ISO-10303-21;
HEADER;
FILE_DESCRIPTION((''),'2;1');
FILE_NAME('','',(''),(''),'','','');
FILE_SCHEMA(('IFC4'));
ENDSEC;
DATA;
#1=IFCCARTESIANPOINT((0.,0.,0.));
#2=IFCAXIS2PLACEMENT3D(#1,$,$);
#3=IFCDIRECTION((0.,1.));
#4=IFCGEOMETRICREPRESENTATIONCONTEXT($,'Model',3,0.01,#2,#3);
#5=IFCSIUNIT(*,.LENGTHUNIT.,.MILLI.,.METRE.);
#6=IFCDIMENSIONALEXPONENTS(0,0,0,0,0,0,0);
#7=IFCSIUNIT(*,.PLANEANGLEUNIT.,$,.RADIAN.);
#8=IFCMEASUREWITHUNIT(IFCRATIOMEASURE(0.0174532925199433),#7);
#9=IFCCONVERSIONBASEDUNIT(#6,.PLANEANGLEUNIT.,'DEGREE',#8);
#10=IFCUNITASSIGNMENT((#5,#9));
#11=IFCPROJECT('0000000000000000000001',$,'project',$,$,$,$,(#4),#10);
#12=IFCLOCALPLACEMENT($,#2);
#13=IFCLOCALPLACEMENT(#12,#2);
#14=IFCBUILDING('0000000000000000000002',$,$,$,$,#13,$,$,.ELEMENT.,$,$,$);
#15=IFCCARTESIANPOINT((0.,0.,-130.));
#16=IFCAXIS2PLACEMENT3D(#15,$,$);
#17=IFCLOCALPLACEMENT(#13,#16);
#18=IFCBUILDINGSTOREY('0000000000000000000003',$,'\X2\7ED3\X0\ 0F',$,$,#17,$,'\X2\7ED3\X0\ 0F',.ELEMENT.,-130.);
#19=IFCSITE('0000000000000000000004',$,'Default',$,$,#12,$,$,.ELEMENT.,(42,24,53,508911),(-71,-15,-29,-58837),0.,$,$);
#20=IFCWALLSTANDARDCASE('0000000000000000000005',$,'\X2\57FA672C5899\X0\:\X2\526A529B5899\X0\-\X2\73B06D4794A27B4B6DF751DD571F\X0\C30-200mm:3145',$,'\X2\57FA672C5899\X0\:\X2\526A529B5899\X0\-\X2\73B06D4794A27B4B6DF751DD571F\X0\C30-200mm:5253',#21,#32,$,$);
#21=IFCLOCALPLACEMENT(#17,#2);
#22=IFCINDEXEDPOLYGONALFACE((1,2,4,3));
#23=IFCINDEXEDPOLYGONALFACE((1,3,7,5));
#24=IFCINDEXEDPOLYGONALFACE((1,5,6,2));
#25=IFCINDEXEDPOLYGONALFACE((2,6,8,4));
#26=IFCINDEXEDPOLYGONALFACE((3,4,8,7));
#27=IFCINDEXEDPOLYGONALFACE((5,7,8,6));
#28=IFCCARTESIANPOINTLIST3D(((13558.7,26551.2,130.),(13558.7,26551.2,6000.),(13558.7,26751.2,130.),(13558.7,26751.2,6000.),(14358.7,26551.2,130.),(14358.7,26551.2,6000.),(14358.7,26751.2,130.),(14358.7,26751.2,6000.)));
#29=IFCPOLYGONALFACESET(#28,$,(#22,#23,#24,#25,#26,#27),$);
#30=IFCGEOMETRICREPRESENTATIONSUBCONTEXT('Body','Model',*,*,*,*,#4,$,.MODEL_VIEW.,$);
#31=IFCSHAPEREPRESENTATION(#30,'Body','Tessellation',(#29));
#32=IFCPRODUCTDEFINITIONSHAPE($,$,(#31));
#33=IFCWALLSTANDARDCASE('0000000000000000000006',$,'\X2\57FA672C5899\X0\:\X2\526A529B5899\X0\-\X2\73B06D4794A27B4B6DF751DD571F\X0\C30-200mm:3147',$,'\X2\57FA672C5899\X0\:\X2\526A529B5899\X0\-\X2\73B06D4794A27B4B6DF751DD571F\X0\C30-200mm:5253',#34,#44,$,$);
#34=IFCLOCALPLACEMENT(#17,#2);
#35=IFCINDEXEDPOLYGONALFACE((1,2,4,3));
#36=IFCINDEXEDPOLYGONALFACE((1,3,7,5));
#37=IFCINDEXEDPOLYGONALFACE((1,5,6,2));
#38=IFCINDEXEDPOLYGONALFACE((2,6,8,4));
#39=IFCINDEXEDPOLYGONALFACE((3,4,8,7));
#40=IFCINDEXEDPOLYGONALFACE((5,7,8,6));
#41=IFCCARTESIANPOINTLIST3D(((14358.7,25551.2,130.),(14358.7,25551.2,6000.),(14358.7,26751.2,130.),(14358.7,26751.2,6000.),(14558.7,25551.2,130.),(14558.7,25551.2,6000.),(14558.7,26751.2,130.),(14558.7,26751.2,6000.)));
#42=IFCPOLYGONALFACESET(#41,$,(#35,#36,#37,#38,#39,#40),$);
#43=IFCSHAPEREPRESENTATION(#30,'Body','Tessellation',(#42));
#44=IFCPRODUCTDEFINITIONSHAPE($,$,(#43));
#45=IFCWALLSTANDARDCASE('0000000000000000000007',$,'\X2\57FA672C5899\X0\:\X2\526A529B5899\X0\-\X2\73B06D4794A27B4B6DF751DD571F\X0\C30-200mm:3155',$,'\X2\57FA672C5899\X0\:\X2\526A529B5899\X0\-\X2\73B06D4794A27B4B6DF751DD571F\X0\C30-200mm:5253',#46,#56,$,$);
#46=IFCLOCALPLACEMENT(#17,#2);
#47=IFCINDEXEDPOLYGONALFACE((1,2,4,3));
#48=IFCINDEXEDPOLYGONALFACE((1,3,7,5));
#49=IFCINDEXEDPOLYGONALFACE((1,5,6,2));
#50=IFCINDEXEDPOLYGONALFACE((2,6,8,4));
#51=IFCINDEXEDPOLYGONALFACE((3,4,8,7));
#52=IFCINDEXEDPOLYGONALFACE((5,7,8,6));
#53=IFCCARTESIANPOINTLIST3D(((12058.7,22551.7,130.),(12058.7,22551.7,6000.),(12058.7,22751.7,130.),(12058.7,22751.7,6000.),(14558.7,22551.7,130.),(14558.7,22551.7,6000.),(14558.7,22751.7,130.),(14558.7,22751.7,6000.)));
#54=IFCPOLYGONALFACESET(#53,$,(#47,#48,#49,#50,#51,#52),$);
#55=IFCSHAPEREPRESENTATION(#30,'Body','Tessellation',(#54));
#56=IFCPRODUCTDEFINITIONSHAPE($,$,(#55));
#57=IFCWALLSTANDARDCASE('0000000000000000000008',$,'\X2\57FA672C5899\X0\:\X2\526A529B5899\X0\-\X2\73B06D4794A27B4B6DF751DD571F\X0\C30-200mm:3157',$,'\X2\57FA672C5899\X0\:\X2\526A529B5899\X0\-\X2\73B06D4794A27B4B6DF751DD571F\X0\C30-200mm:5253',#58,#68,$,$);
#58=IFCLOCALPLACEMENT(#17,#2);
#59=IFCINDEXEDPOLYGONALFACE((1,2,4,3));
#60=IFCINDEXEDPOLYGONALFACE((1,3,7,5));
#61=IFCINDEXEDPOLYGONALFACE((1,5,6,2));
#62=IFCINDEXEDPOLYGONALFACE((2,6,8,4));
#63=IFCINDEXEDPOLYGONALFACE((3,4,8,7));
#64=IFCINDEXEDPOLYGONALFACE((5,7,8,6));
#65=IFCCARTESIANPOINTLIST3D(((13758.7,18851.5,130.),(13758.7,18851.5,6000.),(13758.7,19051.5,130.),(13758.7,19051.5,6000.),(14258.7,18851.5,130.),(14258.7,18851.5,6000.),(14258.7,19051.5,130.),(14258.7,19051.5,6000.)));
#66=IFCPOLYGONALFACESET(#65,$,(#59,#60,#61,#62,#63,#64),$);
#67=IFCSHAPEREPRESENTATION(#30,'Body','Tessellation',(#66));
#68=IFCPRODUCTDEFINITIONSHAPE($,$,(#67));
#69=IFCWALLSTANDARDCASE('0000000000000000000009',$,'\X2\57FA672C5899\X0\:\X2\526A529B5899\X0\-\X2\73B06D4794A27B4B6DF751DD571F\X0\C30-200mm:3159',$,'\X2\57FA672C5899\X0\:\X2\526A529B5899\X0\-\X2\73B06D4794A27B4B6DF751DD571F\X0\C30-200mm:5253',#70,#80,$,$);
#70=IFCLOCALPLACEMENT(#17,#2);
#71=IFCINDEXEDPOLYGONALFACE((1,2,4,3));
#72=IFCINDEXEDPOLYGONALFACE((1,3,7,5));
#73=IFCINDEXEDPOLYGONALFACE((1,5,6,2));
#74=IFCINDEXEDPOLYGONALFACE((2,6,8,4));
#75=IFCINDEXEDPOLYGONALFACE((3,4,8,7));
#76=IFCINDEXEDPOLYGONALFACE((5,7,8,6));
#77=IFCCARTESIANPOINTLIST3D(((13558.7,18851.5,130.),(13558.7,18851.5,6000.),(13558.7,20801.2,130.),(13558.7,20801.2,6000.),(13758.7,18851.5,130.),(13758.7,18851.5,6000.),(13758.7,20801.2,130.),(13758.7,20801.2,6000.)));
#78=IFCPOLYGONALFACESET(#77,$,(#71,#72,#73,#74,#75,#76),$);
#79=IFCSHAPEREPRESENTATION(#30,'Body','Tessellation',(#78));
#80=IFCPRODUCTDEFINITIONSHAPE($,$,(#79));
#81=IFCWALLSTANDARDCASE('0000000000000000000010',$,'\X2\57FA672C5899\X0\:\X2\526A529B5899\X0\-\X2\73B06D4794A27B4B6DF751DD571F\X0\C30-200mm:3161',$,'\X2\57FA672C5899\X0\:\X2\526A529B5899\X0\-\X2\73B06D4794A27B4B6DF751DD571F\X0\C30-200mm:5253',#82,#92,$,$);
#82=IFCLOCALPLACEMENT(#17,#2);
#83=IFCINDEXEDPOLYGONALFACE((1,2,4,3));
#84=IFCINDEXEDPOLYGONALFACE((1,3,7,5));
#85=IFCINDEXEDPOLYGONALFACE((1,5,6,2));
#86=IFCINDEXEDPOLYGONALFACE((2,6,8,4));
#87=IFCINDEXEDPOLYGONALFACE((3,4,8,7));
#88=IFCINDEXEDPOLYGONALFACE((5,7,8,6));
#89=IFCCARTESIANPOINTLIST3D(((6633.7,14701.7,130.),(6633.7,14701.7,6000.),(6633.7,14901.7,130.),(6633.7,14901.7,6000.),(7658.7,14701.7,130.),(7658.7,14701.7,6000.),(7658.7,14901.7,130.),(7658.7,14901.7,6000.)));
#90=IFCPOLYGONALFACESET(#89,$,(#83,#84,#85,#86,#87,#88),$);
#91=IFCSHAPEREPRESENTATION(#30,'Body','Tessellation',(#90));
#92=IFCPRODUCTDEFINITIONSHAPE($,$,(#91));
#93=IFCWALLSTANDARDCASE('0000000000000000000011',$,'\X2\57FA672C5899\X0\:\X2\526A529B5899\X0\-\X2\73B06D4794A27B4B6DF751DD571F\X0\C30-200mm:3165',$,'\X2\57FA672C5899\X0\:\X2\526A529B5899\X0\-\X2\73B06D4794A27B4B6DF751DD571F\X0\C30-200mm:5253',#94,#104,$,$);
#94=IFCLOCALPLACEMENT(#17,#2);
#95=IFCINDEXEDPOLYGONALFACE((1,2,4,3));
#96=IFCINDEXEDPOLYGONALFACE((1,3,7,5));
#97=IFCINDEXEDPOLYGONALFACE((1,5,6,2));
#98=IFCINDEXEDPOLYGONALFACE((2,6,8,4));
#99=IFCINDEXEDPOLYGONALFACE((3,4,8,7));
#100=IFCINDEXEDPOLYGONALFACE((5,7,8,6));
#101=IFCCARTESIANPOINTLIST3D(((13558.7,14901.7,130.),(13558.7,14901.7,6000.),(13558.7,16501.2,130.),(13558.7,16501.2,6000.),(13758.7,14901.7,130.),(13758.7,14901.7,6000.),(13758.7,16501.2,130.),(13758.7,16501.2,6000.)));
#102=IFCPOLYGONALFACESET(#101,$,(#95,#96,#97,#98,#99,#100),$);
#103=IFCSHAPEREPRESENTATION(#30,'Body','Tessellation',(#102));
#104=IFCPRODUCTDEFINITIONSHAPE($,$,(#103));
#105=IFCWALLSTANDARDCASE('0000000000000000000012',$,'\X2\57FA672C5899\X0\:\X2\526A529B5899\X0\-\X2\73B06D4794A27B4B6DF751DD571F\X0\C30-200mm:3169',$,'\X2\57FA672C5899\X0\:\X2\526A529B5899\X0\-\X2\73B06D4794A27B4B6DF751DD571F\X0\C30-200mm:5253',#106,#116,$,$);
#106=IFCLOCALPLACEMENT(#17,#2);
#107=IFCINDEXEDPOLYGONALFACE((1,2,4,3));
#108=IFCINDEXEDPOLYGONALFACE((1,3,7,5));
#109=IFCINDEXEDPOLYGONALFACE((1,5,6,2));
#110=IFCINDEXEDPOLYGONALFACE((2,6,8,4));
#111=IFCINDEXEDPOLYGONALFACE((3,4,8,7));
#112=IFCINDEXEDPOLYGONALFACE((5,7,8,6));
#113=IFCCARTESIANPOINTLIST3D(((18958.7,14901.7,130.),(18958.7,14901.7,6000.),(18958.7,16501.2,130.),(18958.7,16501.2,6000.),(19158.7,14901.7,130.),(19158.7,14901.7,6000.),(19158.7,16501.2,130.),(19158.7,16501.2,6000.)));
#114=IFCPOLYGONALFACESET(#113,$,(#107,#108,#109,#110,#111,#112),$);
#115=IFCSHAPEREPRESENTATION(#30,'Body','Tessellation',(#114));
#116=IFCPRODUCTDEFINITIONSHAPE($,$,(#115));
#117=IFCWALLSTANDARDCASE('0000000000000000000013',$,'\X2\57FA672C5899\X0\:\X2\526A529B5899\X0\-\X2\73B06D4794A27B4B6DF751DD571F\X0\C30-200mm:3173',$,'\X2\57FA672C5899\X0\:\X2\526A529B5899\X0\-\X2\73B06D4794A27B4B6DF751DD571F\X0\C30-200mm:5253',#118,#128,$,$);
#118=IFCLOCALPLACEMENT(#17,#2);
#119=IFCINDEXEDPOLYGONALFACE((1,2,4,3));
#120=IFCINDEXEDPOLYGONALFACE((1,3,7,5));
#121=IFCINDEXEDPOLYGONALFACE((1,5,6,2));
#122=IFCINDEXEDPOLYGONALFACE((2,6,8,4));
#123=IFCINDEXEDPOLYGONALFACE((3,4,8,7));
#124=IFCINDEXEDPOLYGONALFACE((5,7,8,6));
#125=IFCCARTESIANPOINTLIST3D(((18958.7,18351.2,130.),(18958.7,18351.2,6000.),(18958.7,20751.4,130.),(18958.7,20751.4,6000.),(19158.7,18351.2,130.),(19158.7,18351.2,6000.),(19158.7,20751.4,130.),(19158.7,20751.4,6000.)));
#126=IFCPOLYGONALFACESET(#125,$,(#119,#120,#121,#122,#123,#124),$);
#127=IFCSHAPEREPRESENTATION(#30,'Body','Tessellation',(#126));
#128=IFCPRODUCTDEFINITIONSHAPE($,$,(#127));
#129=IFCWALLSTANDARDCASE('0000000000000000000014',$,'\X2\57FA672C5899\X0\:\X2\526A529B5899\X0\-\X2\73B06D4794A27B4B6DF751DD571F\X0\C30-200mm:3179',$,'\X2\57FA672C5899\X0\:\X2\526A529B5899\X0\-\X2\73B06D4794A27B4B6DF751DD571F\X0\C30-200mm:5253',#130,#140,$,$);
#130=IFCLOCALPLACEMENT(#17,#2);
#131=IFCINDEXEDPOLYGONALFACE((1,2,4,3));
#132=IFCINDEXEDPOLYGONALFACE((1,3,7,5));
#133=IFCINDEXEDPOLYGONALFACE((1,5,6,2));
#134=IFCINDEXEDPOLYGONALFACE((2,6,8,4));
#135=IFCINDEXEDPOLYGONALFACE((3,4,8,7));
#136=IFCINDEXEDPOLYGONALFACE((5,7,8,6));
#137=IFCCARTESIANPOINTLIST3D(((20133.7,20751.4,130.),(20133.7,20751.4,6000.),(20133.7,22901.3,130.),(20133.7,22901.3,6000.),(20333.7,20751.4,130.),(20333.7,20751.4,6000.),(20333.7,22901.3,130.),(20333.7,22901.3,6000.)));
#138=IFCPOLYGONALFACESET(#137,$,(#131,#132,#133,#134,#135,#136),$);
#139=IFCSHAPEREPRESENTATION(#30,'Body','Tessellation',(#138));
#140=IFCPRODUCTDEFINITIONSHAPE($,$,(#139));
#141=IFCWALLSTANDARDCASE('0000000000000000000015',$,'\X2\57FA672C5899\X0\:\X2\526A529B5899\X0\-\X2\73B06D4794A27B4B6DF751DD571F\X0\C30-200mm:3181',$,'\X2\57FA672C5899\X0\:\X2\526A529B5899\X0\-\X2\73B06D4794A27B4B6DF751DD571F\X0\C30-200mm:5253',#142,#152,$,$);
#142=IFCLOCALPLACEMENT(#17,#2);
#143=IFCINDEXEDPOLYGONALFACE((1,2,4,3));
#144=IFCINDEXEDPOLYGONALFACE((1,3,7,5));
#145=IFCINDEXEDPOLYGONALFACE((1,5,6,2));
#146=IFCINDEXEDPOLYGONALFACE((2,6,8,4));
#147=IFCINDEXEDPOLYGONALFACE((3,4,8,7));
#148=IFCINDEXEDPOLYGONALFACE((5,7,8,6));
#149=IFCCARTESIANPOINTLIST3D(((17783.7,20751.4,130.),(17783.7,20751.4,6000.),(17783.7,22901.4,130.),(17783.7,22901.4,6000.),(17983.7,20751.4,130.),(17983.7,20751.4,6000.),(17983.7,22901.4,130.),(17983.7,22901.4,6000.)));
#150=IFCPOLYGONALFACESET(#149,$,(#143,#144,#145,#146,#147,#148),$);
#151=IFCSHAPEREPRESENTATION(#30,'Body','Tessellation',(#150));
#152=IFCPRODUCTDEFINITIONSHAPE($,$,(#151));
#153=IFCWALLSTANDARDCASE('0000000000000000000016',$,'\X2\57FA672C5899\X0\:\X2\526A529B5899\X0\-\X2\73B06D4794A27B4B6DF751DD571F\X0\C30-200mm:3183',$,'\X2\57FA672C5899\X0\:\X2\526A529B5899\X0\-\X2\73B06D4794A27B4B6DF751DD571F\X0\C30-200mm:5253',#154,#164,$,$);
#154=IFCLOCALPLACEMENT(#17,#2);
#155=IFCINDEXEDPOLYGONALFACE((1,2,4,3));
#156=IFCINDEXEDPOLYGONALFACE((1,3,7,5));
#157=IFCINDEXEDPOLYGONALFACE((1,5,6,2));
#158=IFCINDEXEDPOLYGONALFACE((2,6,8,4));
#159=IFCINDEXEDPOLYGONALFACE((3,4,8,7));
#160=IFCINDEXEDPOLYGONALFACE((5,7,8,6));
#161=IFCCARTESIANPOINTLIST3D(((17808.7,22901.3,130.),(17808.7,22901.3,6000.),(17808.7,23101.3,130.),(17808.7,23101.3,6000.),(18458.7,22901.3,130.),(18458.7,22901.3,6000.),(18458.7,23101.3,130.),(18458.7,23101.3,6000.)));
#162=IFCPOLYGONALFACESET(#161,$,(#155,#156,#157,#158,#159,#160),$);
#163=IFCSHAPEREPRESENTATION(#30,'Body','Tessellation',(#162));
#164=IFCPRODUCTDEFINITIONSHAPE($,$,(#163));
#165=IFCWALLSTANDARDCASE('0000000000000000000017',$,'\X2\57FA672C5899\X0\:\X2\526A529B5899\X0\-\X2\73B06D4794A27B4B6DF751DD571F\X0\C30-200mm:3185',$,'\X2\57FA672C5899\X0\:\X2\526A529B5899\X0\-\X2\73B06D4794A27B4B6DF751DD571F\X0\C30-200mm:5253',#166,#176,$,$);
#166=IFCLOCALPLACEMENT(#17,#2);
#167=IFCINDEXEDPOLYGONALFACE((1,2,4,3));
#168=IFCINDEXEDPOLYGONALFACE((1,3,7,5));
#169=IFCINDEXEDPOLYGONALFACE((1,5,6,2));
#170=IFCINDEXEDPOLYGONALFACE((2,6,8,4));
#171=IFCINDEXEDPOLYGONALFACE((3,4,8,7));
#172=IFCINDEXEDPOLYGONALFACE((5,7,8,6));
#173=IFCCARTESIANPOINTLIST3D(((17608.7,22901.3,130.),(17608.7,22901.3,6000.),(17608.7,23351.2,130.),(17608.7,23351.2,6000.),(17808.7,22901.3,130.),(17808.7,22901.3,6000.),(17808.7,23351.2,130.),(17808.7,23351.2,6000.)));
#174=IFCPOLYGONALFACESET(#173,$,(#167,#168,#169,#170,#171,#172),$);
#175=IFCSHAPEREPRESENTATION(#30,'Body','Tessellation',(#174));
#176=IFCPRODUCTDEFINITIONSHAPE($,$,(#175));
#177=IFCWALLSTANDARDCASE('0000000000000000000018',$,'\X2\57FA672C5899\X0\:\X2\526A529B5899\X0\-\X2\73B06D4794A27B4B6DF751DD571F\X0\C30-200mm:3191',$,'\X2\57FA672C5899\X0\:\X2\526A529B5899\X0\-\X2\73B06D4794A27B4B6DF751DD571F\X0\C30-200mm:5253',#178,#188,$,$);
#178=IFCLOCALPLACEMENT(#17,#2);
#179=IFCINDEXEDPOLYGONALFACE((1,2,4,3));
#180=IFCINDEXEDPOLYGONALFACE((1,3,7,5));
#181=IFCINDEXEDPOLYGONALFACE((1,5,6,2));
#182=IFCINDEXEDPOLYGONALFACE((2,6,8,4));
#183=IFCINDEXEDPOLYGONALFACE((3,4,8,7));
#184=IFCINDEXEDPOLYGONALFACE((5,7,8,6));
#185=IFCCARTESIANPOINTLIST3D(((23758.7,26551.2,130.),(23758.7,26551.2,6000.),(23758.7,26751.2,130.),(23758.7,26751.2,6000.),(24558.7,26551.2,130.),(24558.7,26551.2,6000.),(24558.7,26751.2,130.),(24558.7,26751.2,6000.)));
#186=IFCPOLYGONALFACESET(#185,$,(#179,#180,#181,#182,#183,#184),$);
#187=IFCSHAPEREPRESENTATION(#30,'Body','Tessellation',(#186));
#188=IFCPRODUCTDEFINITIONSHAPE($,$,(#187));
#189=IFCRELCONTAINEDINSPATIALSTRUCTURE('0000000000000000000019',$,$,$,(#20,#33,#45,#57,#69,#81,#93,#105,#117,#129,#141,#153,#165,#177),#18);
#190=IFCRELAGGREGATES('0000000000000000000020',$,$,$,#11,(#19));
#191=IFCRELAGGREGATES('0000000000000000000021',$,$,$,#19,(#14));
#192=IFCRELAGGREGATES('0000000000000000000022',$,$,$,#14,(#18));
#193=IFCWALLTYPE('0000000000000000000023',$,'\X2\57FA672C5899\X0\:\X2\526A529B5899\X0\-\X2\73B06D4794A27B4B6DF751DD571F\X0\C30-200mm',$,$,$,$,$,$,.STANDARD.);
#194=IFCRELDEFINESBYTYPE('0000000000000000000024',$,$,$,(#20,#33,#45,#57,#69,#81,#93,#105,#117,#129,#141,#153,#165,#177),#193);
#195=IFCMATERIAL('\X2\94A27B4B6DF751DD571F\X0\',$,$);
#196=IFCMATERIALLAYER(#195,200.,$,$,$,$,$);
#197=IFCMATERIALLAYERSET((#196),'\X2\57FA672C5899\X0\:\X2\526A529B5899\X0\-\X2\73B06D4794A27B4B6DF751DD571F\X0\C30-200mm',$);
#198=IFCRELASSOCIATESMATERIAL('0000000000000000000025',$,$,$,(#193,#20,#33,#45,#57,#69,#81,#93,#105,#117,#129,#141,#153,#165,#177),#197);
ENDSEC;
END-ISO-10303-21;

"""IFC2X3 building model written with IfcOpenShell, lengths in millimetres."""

from ifc_helpers import new_model, entity, si_unit, converted_unit, direction, frame, frame_2d, origin, place, context, subcontext, project, spatial, rectangle, extrude, material, layer, layer_set, layer_usage, type_object, element, save


model = new_model("IFC2X3")

# Units and contexts
model_context = context("Model", 3, precision=0.01, world=origin(), true_north=direction((0.0, 1.0)))
body_context = subcontext(model_context, "Body", "Model", "MODEL_VIEW")
ifc_project = project(units=[si_unit("LENGTHUNIT", "METRE", prefix="MILLI"), converted_unit("PLANEANGLEUNIT", "DEGREE", entity("IfcRatioMeasure", 0.0174532925199433), si_unit("PLANEANGLEUNIT", "RADIAN"), dimensions=[0, 0, 0, 0, 0, 0, 0])], contexts=[model_context])

# Site, building, storey
site_placement = place(None, origin())
site = spatial("IfcSite", under=ifc_project, at=site_placement, Name="Default", CompositionType="ELEMENT", RefLatitude=(42, 24, 53, 508911), RefLongitude=(-71, -15, -29, -58837), RefElevation=0.0)
building_placement = place(site_placement, origin())
building = spatial("IfcBuilding", under=site, at=building_placement, CompositionType="ELEMENT")
storey_placement = place(building_placement, frame((0.0, 0.0, -130.0)))
storey = spatial("IfcBuildingStorey", under=building, at=storey_placement, Name="结 0F", LongName="结 0F", CompositionType="ELEMENT", Elevation=-130.0)

# Walls
ifc_material = material(Name="钢筋混凝土")
ifc_layer_1 = layer(ifc_material, 200.0)
ifc_layer_set_1 = layer_set([ifc_layer_1], Name="基本墙:剪力墙-现浇钢筋混凝土C30-200mm")
ifc_layer_usage_1 = layer_usage(ifc_layer_set_1, "AXIS2", "NEGATIVE", 100.0)
wall_type_1 = type_object("IfcWallType", Name="基本墙:剪力墙-现浇钢筋混凝土C30-200mm", PredefinedType="STANDARD", material=ifc_layer_set_1)
wall_1_placement = place(storey_placement, frame((13558.7, 26651.2, 130.0)))
element("IfcWallStandardCase", 1, at=wall_1_placement, inside=storey, type_object=wall_type_1, material=ifc_layer_usage_1, Name="基本墙:剪力墙-现浇钢筋混凝土C30-200mm:3145", ObjectType="基本墙:剪力墙-现浇钢筋混凝土C30-200mm:5253", context=body_context, shape_type="SweptSolid", body=[
    extrude(rectangle(XDim=800.0, YDim=200.0, at=frame_2d((400.0, 0.0), x_axis=(-1.0, 0.0))), origin(), (0.0, 0.0, 1.0), 5870.0),
])
ifc_layer_usage_2 = layer_usage(ifc_layer_set_1, "AXIS2", "NEGATIVE", 100.0)
wall_2_placement = place(storey_placement, frame((14458.7, 26751.2, 130.0), z_axis=(0.0, 0.0, 1.0), x_axis=(0.0, -1.0, 0.0)))
element("IfcWallStandardCase", 2, at=wall_2_placement, inside=storey, type_object=wall_type_1, material=ifc_layer_usage_2, Name="基本墙:剪力墙-现浇钢筋混凝土C30-200mm:3147", ObjectType="基本墙:剪力墙-现浇钢筋混凝土C30-200mm:5253", context=body_context, shape_type="SweptSolid", body=[
    extrude(rectangle(XDim=1200.0, YDim=200.0, at=frame_2d((600.0, 0.0), x_axis=(-1.0, 0.0))), origin(), (0.0, 0.0, 1.0), 5870.0),
])
ifc_layer_usage_3 = layer_usage(ifc_layer_set_1, "AXIS2", "NEGATIVE", 100.0)
wall_3_placement = place(storey_placement, frame((12058.7, 22651.7, 130.0)))
element("IfcWallStandardCase", 3, at=wall_3_placement, inside=storey, type_object=wall_type_1, material=ifc_layer_usage_3, Name="基本墙:剪力墙-现浇钢筋混凝土C30-200mm:3155", ObjectType="基本墙:剪力墙-现浇钢筋混凝土C30-200mm:5253", context=body_context, shape_type="SweptSolid", body=[
    extrude(rectangle(XDim=2500.0, YDim=200.0, at=frame_2d((1250.0, 0.0), x_axis=(-1.0, 0.0))), origin(), (0.0, 0.0, 1.0), 5870.0),
])
ifc_layer_usage_4 = layer_usage(ifc_layer_set_1, "AXIS2", "NEGATIVE", 100.0)
wall_4_placement = place(storey_placement, frame((14258.7, 18951.5, 130.0), z_axis=(0.0, 0.0, 1.0), x_axis=(-1.0, 0.0, 0.0)))
element("IfcWallStandardCase", 4, at=wall_4_placement, inside=storey, type_object=wall_type_1, material=ifc_layer_usage_4, Name="基本墙:剪力墙-现浇钢筋混凝土C30-200mm:3157", ObjectType="基本墙:剪力墙-现浇钢筋混凝土C30-200mm:5253", context=body_context, shape_type="SweptSolid", body=[
    extrude(rectangle(XDim=500.0, YDim=200.0, at=frame_2d((250.0, 0.0), x_axis=(-1.0, 0.0))), origin(), (0.0, 0.0, 1.0), 5870.0),
])
ifc_layer_usage_5 = layer_usage(ifc_layer_set_1, "AXIS2", "NEGATIVE", 100.0)
wall_5_placement = place(storey_placement, frame((13658.7, 18851.5, 130.0), z_axis=(0.0, 0.0, 1.0), x_axis=(0.0, 1.0, 0.0)))
element("IfcWallStandardCase", 5, at=wall_5_placement, inside=storey, type_object=wall_type_1, material=ifc_layer_usage_5, Name="基本墙:剪力墙-现浇钢筋混凝土C30-200mm:3159", ObjectType="基本墙:剪力墙-现浇钢筋混凝土C30-200mm:5253", context=body_context, shape_type="SweptSolid", body=[
    extrude(rectangle(XDim=1949.8, YDim=200.0, at=frame_2d((974.9, 0.0), x_axis=(-1.0, 0.0))), origin(), (0.0, 0.0, 1.0), 5870.0),
])
ifc_layer_usage_6 = layer_usage(ifc_layer_set_1, "AXIS2", "NEGATIVE", 100.0)
wall_6_placement = place(storey_placement, frame((7658.7, 14801.7, 130.0), z_axis=(0.0, 0.0, 1.0), x_axis=(-1.0, 0.0, 0.0)))
element("IfcWallStandardCase", 6, at=wall_6_placement, inside=storey, type_object=wall_type_1, material=ifc_layer_usage_6, Name="基本墙:剪力墙-现浇钢筋混凝土C30-200mm:3161", ObjectType="基本墙:剪力墙-现浇钢筋混凝土C30-200mm:5253", context=body_context, shape_type="SweptSolid", body=[
    extrude(rectangle(XDim=1025.0, YDim=200.0, at=frame_2d((512.5, 0.0), x_axis=(-1.0, 0.0))), origin(), (0.0, 0.0, 1.0), 5870.0),
])
ifc_layer_usage_7 = layer_usage(ifc_layer_set_1, "AXIS2", "NEGATIVE", 100.0)
wall_7_placement = place(storey_placement, frame((13658.7, 14901.7, 130.0), z_axis=(0.0, 0.0, 1.0), x_axis=(0.0, 1.0, 0.0)))
element("IfcWallStandardCase", 7, at=wall_7_placement, inside=storey, type_object=wall_type_1, material=ifc_layer_usage_7, Name="基本墙:剪力墙-现浇钢筋混凝土C30-200mm:3165", ObjectType="基本墙:剪力墙-现浇钢筋混凝土C30-200mm:5253", context=body_context, shape_type="SweptSolid", body=[
    extrude(rectangle(XDim=1599.5, YDim=200.0, at=frame_2d((799.8, 0.0), x_axis=(-1.0, 0.0))), origin(), (0.0, 0.0, 1.0), 5870.0),
])
ifc_layer_usage_8 = layer_usage(ifc_layer_set_1, "AXIS2", "NEGATIVE", 100.0)
wall_8_placement = place(storey_placement, frame((19058.7, 14901.7, 130.0), z_axis=(0.0, 0.0, 1.0), x_axis=(0.0, 1.0, 0.0)))
element("IfcWallStandardCase", 8, at=wall_8_placement, inside=storey, type_object=wall_type_1, material=ifc_layer_usage_8, Name="基本墙:剪力墙-现浇钢筋混凝土C30-200mm:3169", ObjectType="基本墙:剪力墙-现浇钢筋混凝土C30-200mm:5253", context=body_context, shape_type="SweptSolid", body=[
    extrude(rectangle(XDim=1599.5, YDim=200.0, at=frame_2d((799.8, 0.0), x_axis=(-1.0, 0.0))), origin(), (0.0, 0.0, 1.0), 5870.0),
])
ifc_layer_usage_9 = layer_usage(ifc_layer_set_1, "AXIS2", "NEGATIVE", 100.0)
wall_9_placement = place(storey_placement, frame((19058.7, 18351.2, 130.0), z_axis=(0.0, 0.0, 1.0), x_axis=(0.0, 1.0, 0.0)))
element("IfcWallStandardCase", 9, at=wall_9_placement, inside=storey, type_object=wall_type_1, material=ifc_layer_usage_9, Name="基本墙:剪力墙-现浇钢筋混凝土C30-200mm:3173", ObjectType="基本墙:剪力墙-现浇钢筋混凝土C30-200mm:5253", context=body_context, shape_type="SweptSolid", body=[
    extrude(rectangle(XDim=2400.2, YDim=200.0, at=frame_2d((1200.1, 0.0), x_axis=(-1.0, 0.0))), origin(), (0.0, 0.0, 1.0), 5870.0),
])
ifc_layer_usage_10 = layer_usage(ifc_layer_set_1, "AXIS2", "NEGATIVE", 100.0)
wall_10_placement = place(storey_placement, frame((20233.7, 20751.4, 130.0), z_axis=(0.0, 0.0, 1.0), x_axis=(0.0, 1.0, 0.0)))
element("IfcWallStandardCase", 10, at=wall_10_placement, inside=storey, type_object=wall_type_1, material=ifc_layer_usage_10, Name="基本墙:剪力墙-现浇钢筋混凝土C30-200mm:3179", ObjectType="基本墙:剪力墙-现浇钢筋混凝土C30-200mm:5253", context=body_context, shape_type="SweptSolid", body=[
    extrude(rectangle(XDim=2149.9, YDim=200.0, at=frame_2d((1075.0, 0.0), x_axis=(-1.0, 0.0))), origin(), (0.0, 0.0, 1.0), 5870.0),
])
ifc_layer_usage_11 = layer_usage(ifc_layer_set_1, "AXIS2", "NEGATIVE", 100.0)
wall_11_placement = place(storey_placement, frame((17883.7, 20751.4, 130.0), z_axis=(0.0, 0.0, 1.0), x_axis=(0.0, 1.0, 0.0)))
element("IfcWallStandardCase", 11, at=wall_11_placement, inside=storey, type_object=wall_type_1, material=ifc_layer_usage_11, Name="基本墙:剪力墙-现浇钢筋混凝土C30-200mm:3181", ObjectType="基本墙:剪力墙-现浇钢筋混凝土C30-200mm:5253", context=body_context, shape_type="SweptSolid", body=[
    extrude(rectangle(XDim=2150.0, YDim=200.0, at=frame_2d((1075.0, 0.0), x_axis=(-1.0, 0.0))), origin(), (0.0, 0.0, 1.0), 5870.0),
])
ifc_layer_usage_12 = layer_usage(ifc_layer_set_1, "AXIS2", "NEGATIVE", 100.0)
wall_12_placement = place(storey_placement, frame((17808.7, 23001.3, 130.0)))
element("IfcWallStandardCase", 12, at=wall_12_placement, inside=storey, type_object=wall_type_1, material=ifc_layer_usage_12, Name="基本墙:剪力墙-现浇钢筋混凝土C30-200mm:3183", ObjectType="基本墙:剪力墙-现浇钢筋混凝土C30-200mm:5253", context=body_context, shape_type="SweptSolid", body=[
    extrude(rectangle(XDim=650.0, YDim=200.0, at=frame_2d((325.0, 0.0), x_axis=(-1.0, 0.0))), origin(), (0.0, 0.0, 1.0), 5870.0),
])
ifc_layer_usage_13 = layer_usage(ifc_layer_set_1, "AXIS2", "NEGATIVE", 100.0)
wall_13_placement = place(storey_placement, frame((17708.7, 22901.3, 130.0), z_axis=(0.0, 0.0, 1.0), x_axis=(0.0, 1.0, 0.0)))
element("IfcWallStandardCase", 13, at=wall_13_placement, inside=storey, type_object=wall_type_1, material=ifc_layer_usage_13, Name="基本墙:剪力墙-现浇钢筋混凝土C30-200mm:3185", ObjectType="基本墙:剪力墙-现浇钢筋混凝土C30-200mm:5253", context=body_context, shape_type="SweptSolid", body=[
    extrude(rectangle(XDim=449.9, YDim=200.0, at=frame_2d((225.0, 0.0), x_axis=(-1.0, 0.0))), origin(), (0.0, 0.0, 1.0), 5870.0),
])
ifc_layer_usage_14 = layer_usage(ifc_layer_set_1, "AXIS2", "POSITIVE", -100.0)
wall_14_placement = place(storey_placement, frame((24558.7, 26651.2, 130.0), z_axis=(0.0, 0.0, 1.0), x_axis=(-1.0, 0.0, 0.0)))
element("IfcWallStandardCase", 14, at=wall_14_placement, inside=storey, type_object=wall_type_1, material=ifc_layer_usage_14, Name="基本墙:剪力墙-现浇钢筋混凝土C30-200mm:3191", ObjectType="基本墙:剪力墙-现浇钢筋混凝土C30-200mm:5253", context=body_context, shape_type="SweptSolid", body=[
    extrude(rectangle(XDim=800.0, YDim=200.0, at=frame_2d((400.0, 0.0), x_axis=(-1.0, 0.0))), origin(), (0.0, 0.0, 1.0), 5870.0),
])

save(model, "model.ifc")
